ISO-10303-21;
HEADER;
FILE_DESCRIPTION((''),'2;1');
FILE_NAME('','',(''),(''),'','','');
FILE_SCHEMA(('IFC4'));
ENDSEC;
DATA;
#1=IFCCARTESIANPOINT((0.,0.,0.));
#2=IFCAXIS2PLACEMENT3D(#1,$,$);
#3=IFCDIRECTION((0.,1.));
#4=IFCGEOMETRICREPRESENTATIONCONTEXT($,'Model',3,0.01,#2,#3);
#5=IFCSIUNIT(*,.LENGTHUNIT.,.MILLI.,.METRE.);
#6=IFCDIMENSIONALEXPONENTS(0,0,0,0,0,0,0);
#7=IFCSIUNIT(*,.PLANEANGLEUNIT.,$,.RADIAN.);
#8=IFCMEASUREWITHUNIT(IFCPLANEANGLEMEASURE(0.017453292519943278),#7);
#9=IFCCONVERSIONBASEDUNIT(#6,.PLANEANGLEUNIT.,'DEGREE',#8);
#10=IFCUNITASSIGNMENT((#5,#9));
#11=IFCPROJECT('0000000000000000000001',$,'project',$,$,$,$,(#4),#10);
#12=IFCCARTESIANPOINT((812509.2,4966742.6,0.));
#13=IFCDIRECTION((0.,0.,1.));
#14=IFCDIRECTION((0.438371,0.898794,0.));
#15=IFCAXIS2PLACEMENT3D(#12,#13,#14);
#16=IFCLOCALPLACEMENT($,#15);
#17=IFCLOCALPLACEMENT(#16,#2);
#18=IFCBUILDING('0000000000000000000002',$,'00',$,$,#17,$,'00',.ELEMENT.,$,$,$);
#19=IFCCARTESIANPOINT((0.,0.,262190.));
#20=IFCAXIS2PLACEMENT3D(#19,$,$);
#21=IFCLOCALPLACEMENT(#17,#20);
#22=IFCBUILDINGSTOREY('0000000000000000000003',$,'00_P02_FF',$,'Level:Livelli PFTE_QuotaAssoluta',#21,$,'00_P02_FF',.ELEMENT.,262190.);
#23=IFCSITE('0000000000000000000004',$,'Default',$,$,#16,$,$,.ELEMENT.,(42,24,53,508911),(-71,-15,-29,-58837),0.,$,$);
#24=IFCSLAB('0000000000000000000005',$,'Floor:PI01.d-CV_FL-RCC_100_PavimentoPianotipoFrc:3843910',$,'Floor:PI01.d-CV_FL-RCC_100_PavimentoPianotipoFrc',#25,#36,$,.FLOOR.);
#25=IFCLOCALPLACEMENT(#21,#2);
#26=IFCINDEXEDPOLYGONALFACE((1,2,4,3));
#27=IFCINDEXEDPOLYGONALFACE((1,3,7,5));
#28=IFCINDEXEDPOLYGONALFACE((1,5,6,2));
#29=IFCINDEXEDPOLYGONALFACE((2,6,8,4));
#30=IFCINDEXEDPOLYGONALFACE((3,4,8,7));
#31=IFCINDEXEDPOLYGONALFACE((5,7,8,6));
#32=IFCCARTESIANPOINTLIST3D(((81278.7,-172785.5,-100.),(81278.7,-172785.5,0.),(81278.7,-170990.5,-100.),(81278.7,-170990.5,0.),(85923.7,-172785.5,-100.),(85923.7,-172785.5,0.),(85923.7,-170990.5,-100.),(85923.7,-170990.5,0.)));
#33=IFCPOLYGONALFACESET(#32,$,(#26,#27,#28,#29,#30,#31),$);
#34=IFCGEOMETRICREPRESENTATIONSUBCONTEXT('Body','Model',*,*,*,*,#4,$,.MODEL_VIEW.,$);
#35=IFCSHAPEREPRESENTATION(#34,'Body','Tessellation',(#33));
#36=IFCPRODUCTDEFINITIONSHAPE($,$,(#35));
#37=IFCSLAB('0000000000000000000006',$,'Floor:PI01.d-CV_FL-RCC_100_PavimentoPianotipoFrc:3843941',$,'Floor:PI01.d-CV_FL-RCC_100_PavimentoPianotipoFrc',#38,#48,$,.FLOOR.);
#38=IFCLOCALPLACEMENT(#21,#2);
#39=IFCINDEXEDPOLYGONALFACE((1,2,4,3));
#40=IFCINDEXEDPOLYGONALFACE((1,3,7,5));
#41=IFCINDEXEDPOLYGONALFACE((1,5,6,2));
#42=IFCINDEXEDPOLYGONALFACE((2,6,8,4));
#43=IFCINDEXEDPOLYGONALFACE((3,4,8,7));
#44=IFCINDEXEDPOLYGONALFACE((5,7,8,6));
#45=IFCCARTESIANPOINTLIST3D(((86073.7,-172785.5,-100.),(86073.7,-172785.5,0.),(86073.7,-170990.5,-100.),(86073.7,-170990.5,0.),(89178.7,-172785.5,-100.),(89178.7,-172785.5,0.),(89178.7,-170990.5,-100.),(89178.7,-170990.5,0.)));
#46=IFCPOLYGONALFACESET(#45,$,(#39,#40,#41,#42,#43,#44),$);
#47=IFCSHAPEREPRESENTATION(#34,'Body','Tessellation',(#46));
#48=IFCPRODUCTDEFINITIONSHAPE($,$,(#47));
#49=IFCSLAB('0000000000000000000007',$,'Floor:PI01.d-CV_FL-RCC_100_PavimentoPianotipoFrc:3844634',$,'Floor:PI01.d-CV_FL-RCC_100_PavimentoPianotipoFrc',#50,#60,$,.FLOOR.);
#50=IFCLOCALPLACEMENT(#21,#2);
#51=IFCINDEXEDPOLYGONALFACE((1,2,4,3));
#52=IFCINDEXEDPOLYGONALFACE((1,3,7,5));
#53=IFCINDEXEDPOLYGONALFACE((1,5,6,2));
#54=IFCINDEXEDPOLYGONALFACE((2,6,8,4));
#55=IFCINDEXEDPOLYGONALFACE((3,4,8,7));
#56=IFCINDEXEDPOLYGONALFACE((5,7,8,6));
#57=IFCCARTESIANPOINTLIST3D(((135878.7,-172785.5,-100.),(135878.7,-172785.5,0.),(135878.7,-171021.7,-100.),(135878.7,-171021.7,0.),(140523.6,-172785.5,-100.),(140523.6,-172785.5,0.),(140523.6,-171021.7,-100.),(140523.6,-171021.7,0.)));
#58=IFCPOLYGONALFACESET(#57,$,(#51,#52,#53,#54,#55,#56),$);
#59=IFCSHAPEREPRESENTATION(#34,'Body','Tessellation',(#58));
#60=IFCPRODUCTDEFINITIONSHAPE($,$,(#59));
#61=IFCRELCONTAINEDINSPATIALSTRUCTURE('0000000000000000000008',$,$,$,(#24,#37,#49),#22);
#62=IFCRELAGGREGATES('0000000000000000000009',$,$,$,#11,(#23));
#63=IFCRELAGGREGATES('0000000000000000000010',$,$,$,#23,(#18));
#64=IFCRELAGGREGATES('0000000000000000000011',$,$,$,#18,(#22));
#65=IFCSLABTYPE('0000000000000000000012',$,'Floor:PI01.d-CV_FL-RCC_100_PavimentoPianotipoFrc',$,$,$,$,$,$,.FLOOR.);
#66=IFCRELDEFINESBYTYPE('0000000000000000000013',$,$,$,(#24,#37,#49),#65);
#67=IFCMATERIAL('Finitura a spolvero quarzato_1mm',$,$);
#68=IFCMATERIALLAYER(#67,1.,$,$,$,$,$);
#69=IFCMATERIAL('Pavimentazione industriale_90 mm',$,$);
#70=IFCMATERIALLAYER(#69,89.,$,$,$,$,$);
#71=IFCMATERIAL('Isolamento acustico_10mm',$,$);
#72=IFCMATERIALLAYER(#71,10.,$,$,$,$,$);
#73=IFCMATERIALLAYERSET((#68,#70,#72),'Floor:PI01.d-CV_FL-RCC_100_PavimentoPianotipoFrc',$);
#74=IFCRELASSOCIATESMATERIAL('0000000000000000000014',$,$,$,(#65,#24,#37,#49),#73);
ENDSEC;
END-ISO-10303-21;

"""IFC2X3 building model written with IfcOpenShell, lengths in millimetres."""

from ifc_helpers import new_model, entity, si_unit, converted_unit, direction, frame, frame_2d, origin, origin_2d_with_axis, place, context, subcontext, project, spatial, rectangle, extrude, material, layer, layer_set, layer_usage, type_object, element, save


model = new_model("IFC2X3")

# Units and contexts
model_context = context("Model", 3, precision=0.01, world=origin(), true_north=direction((0.0, 1.0)))
body_context = subcontext(model_context, "Body", "Model", "MODEL_VIEW")
ifc_project = project(units=[si_unit("LENGTHUNIT", "METRE", prefix="MILLI"), converted_unit("PLANEANGLEUNIT", "DEGREE", entity("IfcPlaneAngleMeasure", 0.017453292519943278), si_unit("PLANEANGLEUNIT", "RADIAN"), dimensions=[0, 0, 0, 0, 0, 0, 0])], contexts=[model_context])

# Site, building, storey
site_placement = place(None, frame((812509.2, 4966742.6, 0.0), z_axis=(0.0, 0.0, 1.0), x_axis=(0.438371, 0.898794, 0.0)))
site = spatial("IfcSite", under=ifc_project, at=site_placement, Name="Default", CompositionType="ELEMENT", RefLatitude=(42, 24, 53, 508911), RefLongitude=(-71, -15, -29, -58837), RefElevation=0.0)
building_placement = place(site_placement, origin())
building = spatial("IfcBuilding", under=site, at=building_placement, Name="00", LongName="00", CompositionType="ELEMENT")
storey_placement = place(building_placement, frame((0.0, 0.0, 262190.0)))
storey = spatial("IfcBuildingStorey", under=building, at=storey_placement, Name="00_P02_FF", ObjectType="Level:Livelli PFTE_QuotaAssoluta", LongName="00_P02_FF", CompositionType="ELEMENT", Elevation=262190.0)

# Slabs
ifc_material_1 = material(Name="Isolamento acustico_10mm")
ifc_material_2 = material(Name="Finitura a spolvero quarzato_1mm")
ifc_layer_1 = layer(ifc_material_2, 1.0)
ifc_material_3 = material(Name="Pavimentazione industriale_90 mm")
ifc_layer_2 = layer(ifc_material_3, 89.0)
ifc_layer_3 = layer(ifc_material_1, 10.0)
ifc_layer_set_1 = layer_set([ifc_layer_1, ifc_layer_2, ifc_layer_3], Name="Floor:PI01.d-CV_FL-RCC_100_PavimentoPianotipoFrc")
slab_type_1 = type_object("IfcSlabType", Name="Floor:PI01.d-CV_FL-RCC_100_PavimentoPianotipoFrc", PredefinedType="FLOOR", material=ifc_layer_set_1)
ifc_layer_usage_1 = layer_usage(ifc_layer_set_1, "AXIS3", "POSITIVE", 0.0)
slab_1_placement = place(storey_placement, origin())
element("IfcSlab", 1, at=slab_1_placement, inside=storey, type_object=slab_type_1, material=ifc_layer_usage_1, Name="Floor:PI01.d-CV_FL-RCC_100_PavimentoPianotipoFrc:3843910", ObjectType="Floor:PI01.d-CV_FL-RCC_100_PavimentoPianotipoFrc", PredefinedType="FLOOR", context=body_context, shape_type="SweptSolid", body=[
    extrude(rectangle(XDim=1795.0, YDim=4645.0, at=origin_2d_with_axis()), frame((83601.2, -171888.0, 0.0), z_axis=(0.0, 0.0, -1.0), x_axis=(0.0, 1.0, 0.0)), (0.0, 0.0, 1.0), 100.0),
])
ifc_layer_usage_2 = layer_usage(ifc_layer_set_1, "AXIS3", "POSITIVE", 0.0)
slab_2_placement = place(storey_placement, origin())
element("IfcSlab", 2, at=slab_2_placement, inside=storey, type_object=slab_type_1, material=ifc_layer_usage_2, Name="Floor:PI01.d-CV_FL-RCC_100_PavimentoPianotipoFrc:3843941", ObjectType="Floor:PI01.d-CV_FL-RCC_100_PavimentoPianotipoFrc", PredefinedType="FLOOR", context=body_context, shape_type="SweptSolid", body=[
    extrude(rectangle(XDim=1795.0, YDim=3105.0, at=frame_2d((0.0, 0.0), x_axis=(1.0, 0.0))), frame((87626.2, -171888.0, 0.0), z_axis=(0.0, 0.0, -1.0), x_axis=(0.0, 1.0, 0.0)), (0.0, 0.0, 1.0), 100.0),
])
ifc_layer_usage_3 = layer_usage(ifc_layer_set_1, "AXIS3", "POSITIVE", 0.0)
slab_3_placement = place(storey_placement, origin())
element("IfcSlab", 3, at=slab_3_placement, inside=storey, type_object=slab_type_1, material=ifc_layer_usage_3, Name="Floor:PI01.d-CV_FL-RCC_100_PavimentoPianotipoFrc:3844634", ObjectType="Floor:PI01.d-CV_FL-RCC_100_PavimentoPianotipoFrc", PredefinedType="FLOOR", context=body_context, shape_type="SweptSolid", body=[
    extrude(rectangle(XDim=1763.7, YDim=4645.0, at=frame_2d((0.0, 0.0), x_axis=(1.0, 0.0))), frame((138201.2, -171903.6, 0.0), z_axis=(0.0, 0.0, -1.0), x_axis=(0.0, 1.0, 0.0)), (0.0, 0.0, 1.0), 100.0),
])

save(model, "model.ifc")
